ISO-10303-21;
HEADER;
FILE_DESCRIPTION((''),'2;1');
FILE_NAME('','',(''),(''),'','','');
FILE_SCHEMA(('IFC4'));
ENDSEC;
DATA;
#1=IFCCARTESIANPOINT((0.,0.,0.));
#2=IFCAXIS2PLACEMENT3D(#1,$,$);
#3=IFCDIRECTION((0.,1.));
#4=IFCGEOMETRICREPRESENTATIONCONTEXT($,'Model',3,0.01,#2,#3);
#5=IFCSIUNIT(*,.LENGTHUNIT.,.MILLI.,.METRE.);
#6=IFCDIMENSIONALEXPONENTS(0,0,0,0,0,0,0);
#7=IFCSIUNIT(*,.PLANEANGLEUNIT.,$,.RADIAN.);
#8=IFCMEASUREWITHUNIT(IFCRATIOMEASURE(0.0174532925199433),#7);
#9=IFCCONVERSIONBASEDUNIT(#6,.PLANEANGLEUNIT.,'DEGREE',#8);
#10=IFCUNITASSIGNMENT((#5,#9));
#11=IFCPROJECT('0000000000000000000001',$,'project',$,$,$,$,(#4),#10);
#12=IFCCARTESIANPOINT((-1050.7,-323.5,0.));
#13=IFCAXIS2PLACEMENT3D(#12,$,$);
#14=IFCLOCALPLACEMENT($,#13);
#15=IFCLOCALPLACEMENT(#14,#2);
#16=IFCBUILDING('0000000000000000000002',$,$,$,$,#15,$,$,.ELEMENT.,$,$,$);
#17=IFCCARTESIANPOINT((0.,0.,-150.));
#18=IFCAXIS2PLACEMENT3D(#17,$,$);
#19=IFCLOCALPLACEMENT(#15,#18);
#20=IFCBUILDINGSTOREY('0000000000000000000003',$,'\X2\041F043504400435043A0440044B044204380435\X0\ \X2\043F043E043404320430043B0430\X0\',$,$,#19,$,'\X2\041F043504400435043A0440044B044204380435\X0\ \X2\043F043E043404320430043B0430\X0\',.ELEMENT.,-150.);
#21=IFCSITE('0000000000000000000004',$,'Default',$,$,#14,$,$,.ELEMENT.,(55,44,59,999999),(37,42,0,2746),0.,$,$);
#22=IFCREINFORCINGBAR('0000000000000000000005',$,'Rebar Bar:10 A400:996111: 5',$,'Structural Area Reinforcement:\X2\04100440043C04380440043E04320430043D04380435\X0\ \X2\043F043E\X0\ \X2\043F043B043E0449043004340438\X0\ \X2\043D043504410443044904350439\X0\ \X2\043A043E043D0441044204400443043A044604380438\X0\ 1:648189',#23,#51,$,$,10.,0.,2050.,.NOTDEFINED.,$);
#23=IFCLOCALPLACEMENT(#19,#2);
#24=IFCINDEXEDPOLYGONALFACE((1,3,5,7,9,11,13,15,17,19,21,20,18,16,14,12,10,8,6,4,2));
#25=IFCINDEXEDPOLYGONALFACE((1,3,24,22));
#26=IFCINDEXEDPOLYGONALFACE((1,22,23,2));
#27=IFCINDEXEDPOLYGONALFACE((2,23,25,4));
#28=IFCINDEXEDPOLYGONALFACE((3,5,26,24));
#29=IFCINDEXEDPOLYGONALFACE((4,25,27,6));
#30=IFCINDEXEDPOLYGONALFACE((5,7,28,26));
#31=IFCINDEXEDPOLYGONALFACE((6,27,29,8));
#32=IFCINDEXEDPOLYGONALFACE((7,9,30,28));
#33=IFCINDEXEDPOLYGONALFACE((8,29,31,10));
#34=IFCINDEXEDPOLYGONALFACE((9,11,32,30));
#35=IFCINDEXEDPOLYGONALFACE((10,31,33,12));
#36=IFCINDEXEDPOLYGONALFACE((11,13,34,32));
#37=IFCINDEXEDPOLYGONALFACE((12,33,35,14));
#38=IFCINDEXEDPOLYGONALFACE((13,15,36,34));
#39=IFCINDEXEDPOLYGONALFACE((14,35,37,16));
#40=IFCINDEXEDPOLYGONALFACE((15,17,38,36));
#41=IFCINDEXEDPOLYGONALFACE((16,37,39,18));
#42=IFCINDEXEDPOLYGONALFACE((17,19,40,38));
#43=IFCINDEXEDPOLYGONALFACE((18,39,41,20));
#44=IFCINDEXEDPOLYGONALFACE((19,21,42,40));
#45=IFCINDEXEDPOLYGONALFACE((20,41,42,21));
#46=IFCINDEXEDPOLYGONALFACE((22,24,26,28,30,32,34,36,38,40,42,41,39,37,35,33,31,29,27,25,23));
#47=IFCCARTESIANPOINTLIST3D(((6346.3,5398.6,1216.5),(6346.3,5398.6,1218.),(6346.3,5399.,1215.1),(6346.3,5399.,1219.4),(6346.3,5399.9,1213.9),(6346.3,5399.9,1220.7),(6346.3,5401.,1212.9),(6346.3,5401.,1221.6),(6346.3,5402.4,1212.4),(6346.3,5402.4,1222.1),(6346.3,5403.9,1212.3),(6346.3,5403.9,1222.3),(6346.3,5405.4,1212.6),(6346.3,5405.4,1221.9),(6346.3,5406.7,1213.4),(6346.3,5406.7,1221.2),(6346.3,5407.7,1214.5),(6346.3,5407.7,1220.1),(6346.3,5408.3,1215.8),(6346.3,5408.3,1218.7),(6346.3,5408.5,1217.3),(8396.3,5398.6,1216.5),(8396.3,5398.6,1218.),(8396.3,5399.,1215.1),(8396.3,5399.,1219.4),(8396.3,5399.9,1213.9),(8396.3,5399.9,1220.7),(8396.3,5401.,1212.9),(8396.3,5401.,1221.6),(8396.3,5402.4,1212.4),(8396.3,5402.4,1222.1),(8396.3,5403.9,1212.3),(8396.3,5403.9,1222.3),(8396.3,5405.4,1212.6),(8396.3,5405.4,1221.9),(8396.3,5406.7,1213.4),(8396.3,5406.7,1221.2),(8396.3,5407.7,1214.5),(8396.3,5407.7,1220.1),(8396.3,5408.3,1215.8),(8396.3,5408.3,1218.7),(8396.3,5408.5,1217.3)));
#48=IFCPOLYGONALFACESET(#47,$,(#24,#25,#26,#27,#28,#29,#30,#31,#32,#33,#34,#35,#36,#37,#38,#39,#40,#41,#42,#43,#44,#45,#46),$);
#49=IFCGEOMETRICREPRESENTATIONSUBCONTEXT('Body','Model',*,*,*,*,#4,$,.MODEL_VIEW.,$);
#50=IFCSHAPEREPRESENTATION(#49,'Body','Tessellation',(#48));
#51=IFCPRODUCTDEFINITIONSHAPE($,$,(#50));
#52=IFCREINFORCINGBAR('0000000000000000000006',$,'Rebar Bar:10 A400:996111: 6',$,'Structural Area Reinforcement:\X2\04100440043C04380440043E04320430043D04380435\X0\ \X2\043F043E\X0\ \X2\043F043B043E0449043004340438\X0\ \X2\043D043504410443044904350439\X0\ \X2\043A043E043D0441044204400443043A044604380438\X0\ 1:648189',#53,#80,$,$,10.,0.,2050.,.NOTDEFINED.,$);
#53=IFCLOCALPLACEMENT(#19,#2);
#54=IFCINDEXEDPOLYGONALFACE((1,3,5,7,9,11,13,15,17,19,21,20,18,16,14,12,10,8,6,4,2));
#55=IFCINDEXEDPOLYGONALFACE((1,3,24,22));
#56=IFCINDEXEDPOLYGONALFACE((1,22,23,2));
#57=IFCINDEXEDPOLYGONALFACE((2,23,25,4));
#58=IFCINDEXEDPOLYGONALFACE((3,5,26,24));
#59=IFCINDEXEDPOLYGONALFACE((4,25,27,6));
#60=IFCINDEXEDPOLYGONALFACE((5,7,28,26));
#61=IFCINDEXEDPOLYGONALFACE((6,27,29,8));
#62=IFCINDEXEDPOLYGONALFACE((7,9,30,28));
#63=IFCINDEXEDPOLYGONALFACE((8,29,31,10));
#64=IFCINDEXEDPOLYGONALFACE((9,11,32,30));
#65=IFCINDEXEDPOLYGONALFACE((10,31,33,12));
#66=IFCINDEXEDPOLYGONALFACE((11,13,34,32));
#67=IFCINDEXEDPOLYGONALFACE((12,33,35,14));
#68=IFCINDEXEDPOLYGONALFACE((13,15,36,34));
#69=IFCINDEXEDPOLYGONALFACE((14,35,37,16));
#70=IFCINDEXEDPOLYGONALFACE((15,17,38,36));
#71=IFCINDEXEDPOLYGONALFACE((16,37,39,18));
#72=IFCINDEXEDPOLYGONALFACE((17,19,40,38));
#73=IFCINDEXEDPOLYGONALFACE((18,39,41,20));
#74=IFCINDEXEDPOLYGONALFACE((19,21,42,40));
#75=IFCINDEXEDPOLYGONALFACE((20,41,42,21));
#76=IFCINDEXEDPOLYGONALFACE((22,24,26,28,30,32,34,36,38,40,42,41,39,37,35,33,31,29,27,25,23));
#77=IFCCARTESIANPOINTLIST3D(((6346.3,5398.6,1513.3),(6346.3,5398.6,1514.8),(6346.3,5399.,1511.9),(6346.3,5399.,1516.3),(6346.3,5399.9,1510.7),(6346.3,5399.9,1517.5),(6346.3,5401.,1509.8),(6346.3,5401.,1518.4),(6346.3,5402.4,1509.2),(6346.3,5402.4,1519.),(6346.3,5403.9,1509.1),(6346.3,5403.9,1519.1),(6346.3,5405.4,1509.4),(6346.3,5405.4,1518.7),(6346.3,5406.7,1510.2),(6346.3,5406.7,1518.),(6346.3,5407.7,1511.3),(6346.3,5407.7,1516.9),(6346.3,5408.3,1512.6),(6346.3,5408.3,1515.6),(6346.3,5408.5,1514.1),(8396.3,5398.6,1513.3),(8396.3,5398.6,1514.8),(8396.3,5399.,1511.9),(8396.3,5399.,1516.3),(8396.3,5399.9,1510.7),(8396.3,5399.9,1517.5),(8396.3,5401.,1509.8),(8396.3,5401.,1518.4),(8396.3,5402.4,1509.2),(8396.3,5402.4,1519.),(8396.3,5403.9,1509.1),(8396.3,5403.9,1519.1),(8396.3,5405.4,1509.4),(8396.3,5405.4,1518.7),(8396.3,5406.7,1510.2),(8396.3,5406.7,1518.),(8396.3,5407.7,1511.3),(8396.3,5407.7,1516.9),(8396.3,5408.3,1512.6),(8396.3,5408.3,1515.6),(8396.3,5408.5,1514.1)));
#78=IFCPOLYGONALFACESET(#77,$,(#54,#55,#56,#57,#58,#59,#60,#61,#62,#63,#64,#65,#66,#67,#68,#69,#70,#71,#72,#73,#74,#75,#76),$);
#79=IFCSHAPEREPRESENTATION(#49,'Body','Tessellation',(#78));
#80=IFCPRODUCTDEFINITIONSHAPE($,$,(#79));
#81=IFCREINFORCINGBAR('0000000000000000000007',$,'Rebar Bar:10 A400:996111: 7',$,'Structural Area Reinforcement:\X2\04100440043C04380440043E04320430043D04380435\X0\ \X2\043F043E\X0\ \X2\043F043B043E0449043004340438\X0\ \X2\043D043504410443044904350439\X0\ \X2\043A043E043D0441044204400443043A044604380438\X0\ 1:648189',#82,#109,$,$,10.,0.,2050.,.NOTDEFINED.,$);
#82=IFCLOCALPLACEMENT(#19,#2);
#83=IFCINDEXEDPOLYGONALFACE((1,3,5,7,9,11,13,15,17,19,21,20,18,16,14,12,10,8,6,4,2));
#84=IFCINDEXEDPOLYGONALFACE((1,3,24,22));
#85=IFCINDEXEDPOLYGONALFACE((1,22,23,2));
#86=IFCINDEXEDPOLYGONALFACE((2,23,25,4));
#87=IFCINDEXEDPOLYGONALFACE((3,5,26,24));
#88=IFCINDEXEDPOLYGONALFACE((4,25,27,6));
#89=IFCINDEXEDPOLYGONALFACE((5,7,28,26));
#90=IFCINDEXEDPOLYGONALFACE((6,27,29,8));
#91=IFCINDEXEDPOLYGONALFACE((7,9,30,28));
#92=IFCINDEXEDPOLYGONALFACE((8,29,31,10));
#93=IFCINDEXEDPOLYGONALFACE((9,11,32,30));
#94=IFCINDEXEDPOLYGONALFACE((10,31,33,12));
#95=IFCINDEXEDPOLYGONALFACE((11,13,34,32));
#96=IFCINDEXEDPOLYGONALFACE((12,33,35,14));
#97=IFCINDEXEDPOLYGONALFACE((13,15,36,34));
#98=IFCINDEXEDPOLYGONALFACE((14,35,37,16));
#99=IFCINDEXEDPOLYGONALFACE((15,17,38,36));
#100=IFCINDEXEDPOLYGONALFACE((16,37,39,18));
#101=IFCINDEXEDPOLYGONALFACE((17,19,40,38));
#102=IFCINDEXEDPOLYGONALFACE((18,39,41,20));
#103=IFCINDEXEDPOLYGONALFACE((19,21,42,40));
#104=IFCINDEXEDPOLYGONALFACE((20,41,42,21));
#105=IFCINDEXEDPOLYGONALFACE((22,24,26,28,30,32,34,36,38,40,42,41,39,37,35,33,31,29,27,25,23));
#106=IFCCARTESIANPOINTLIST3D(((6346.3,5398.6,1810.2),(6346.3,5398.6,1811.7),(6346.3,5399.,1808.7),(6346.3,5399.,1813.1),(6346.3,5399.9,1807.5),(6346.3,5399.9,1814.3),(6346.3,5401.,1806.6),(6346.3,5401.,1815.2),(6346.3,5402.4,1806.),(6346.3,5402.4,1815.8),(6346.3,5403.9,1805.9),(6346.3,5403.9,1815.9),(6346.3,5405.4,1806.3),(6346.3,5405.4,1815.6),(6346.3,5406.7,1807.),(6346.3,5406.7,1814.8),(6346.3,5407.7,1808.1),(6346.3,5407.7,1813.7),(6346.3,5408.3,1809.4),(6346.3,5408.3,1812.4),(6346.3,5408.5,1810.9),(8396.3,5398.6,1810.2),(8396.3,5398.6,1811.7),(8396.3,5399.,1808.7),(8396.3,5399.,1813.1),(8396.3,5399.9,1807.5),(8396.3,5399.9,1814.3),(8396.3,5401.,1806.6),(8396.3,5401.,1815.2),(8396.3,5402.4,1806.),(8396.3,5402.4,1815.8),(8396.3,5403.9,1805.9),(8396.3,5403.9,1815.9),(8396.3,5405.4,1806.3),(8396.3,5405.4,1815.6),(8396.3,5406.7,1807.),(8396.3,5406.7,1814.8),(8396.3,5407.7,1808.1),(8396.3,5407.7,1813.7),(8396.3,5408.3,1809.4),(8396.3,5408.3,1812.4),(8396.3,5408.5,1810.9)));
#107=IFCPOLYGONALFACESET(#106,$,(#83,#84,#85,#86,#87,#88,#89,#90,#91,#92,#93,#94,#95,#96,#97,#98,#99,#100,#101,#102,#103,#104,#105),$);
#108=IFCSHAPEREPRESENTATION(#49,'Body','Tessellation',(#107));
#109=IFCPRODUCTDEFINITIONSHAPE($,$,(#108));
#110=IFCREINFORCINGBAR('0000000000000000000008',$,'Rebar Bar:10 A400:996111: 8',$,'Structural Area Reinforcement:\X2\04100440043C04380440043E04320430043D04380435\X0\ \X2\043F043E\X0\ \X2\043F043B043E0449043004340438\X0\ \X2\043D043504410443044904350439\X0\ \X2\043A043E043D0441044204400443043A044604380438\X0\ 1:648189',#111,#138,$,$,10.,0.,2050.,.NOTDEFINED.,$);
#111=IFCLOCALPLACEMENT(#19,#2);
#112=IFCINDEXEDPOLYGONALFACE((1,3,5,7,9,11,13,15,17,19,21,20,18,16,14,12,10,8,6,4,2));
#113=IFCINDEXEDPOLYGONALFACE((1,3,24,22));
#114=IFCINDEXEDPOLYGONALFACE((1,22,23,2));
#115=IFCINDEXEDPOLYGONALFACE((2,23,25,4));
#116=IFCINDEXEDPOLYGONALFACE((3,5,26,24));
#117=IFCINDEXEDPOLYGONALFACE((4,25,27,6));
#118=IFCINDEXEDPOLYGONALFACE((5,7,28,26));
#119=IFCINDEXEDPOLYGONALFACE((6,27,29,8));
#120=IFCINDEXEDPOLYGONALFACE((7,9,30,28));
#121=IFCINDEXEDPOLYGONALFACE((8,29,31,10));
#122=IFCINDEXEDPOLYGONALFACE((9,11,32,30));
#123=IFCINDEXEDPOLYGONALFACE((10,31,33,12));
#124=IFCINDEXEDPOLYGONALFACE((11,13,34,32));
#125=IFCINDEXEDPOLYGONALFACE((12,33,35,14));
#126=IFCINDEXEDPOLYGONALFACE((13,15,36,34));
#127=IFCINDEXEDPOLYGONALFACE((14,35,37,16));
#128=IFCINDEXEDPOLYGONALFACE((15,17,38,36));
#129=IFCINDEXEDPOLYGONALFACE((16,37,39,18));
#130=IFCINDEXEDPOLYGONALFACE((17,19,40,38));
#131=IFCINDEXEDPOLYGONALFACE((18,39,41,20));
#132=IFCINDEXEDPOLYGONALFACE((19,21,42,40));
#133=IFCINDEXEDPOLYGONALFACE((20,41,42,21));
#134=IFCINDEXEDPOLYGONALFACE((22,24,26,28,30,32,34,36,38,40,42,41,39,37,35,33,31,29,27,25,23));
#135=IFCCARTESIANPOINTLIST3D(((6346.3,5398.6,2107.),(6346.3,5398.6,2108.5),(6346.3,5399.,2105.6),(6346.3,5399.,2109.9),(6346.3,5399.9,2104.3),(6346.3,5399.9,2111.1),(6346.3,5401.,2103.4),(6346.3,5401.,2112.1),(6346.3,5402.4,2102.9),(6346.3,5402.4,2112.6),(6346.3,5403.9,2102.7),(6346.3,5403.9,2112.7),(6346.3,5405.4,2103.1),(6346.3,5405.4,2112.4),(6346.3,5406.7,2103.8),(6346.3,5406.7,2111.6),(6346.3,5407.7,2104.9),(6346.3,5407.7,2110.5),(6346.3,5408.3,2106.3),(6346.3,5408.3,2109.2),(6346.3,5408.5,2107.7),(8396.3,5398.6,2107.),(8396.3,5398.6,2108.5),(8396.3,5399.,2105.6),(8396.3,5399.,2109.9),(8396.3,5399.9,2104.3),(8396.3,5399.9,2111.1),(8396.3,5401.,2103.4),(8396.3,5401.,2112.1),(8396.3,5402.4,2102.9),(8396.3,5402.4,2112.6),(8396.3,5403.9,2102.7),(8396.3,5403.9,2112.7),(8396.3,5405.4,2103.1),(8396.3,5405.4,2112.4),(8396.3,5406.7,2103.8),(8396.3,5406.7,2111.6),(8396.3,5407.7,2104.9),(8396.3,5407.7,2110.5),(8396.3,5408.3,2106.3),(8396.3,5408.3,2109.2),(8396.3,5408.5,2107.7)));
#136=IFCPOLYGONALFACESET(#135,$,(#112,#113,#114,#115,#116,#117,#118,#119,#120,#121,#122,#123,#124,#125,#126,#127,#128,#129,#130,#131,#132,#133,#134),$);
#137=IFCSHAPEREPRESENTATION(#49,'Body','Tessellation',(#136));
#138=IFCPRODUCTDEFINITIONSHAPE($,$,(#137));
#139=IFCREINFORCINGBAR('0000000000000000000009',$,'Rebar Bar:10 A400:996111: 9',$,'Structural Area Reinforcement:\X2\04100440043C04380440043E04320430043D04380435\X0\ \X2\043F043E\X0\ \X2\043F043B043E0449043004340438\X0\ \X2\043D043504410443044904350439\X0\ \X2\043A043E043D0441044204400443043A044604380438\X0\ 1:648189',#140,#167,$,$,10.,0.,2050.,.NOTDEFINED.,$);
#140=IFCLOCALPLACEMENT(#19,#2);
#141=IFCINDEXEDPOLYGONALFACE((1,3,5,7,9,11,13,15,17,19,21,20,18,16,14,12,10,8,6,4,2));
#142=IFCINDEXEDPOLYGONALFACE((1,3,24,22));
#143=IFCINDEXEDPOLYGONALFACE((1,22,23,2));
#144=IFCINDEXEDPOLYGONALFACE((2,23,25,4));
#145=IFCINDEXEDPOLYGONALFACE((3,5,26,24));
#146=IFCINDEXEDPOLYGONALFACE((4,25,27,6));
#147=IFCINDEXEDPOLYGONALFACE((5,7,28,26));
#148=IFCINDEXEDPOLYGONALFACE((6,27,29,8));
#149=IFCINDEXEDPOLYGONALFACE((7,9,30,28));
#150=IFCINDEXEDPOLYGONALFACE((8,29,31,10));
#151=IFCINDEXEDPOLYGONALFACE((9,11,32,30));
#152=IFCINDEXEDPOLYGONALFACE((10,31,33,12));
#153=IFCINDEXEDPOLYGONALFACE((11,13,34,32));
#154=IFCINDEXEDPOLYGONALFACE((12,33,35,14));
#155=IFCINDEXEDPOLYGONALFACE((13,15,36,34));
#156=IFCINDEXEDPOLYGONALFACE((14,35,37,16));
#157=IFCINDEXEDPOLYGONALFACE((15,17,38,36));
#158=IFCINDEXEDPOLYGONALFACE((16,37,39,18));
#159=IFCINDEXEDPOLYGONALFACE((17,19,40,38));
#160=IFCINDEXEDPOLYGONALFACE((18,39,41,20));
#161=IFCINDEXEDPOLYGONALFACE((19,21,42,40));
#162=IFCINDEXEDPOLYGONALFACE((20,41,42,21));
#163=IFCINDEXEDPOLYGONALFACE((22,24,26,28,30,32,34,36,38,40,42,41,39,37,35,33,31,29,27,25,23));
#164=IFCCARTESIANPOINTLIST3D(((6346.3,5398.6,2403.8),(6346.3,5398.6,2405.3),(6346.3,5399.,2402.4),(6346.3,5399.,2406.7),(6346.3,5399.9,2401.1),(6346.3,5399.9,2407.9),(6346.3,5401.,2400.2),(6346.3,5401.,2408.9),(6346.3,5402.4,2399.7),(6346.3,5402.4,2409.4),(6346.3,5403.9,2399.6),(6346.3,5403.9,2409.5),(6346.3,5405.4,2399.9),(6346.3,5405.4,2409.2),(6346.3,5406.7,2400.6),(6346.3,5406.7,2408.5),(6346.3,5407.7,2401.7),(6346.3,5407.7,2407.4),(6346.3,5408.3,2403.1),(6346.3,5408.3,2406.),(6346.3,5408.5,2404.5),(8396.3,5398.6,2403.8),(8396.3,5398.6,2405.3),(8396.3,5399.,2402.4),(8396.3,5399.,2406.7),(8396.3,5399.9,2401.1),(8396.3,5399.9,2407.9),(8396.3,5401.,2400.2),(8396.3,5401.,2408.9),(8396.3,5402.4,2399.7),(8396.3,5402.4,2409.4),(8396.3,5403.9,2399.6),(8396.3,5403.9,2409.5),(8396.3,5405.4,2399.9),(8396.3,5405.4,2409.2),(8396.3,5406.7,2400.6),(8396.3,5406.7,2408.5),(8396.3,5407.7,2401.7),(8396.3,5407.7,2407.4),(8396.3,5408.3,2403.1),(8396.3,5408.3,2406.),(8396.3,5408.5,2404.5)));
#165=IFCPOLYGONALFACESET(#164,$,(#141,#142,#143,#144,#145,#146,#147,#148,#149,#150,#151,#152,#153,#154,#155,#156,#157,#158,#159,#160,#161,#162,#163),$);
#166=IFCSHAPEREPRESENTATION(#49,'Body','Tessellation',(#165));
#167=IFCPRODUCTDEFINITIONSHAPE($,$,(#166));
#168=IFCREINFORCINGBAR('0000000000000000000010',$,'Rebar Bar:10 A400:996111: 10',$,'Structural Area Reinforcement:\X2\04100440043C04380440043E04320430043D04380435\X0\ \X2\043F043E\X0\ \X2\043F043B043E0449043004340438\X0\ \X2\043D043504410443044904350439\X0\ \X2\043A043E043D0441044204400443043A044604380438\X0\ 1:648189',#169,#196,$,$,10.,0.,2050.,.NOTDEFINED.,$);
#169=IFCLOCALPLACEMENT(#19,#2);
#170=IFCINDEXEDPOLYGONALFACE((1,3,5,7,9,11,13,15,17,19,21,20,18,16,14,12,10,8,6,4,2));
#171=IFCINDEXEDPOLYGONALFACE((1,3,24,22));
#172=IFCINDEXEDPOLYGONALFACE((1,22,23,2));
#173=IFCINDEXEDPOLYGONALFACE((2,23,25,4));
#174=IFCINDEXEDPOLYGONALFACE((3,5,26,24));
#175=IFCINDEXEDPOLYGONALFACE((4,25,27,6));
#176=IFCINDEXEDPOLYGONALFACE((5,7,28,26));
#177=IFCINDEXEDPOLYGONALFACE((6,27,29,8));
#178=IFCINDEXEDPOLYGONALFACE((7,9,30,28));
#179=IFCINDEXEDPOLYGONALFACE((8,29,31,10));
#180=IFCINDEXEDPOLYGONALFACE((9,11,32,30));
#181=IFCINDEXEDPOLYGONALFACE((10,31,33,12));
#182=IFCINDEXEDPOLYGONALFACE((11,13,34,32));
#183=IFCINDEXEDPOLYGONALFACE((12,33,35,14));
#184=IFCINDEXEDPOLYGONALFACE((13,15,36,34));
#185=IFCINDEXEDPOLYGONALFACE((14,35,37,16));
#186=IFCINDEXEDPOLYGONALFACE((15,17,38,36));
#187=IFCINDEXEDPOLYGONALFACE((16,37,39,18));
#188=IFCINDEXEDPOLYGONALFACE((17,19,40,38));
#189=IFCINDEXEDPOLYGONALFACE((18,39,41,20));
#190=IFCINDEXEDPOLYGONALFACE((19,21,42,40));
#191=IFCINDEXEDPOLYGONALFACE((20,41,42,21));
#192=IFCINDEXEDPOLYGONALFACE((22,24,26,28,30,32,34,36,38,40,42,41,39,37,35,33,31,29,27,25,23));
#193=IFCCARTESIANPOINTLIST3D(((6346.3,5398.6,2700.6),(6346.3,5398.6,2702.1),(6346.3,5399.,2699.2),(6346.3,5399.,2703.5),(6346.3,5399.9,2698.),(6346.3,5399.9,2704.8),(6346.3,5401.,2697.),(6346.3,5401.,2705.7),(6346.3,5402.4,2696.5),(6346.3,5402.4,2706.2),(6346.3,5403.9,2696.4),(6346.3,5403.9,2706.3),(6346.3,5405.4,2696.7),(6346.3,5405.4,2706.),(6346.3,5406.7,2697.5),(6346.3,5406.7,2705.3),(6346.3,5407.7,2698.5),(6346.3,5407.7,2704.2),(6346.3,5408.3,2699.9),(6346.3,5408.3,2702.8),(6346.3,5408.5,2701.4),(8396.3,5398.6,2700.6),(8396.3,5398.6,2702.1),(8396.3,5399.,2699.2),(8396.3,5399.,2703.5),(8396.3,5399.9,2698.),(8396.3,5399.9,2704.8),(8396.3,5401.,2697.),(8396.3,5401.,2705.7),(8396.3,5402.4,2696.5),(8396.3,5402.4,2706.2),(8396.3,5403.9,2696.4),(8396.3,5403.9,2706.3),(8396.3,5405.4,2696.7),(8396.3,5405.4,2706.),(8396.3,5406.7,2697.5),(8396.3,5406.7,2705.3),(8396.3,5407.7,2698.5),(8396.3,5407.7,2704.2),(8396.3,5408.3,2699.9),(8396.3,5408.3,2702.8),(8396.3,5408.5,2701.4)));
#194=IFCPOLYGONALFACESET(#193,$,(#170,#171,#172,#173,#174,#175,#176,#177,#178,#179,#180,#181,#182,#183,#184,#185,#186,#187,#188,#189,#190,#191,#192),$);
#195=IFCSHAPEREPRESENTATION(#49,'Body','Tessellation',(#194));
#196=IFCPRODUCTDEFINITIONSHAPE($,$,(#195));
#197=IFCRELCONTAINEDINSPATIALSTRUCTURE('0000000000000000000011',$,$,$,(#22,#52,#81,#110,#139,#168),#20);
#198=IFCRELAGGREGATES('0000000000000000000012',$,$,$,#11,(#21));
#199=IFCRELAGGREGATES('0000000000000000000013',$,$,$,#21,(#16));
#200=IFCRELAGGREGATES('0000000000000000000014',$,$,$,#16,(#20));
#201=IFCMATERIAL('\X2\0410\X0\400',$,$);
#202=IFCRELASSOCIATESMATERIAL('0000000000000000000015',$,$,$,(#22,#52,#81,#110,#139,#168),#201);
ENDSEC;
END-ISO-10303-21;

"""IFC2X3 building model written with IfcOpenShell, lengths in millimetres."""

from ifc_helpers import new_model, entity, si_unit, converted_unit, direction, frame, origin, place, context, subcontext, project, spatial, material, element, save


model = new_model("IFC2X3")

# Units and contexts
model_context = context("Model", 3, precision=0.01, world=origin(), true_north=direction((0.0, 1.0)))
body_context = subcontext(model_context, "Body", "Model", "MODEL_VIEW")
ifc_project = project(units=[si_unit("LENGTHUNIT", "METRE", prefix="MILLI"), converted_unit("PLANEANGLEUNIT", "DEGREE", entity("IfcRatioMeasure", 0.0174532925199433), si_unit("PLANEANGLEUNIT", "RADIAN"), dimensions=[0, 0, 0, 0, 0, 0, 0])], contexts=[model_context])

# Site, building, storey
site_placement = place(None, frame((-1050.7, -323.5, 0.0)))
site = spatial("IfcSite", under=ifc_project, at=site_placement, Name="Default", CompositionType="ELEMENT", RefLatitude=(55, 44, 59, 999999), RefLongitude=(37, 42, 0, 2746), RefElevation=0.0)
building_placement = place(site_placement, origin())
building = spatial("IfcBuilding", under=site, at=building_placement, CompositionType="ELEMENT")
storey_placement = place(building_placement, frame((0.0, 0.0, -150.0)))
storey = spatial("IfcBuildingStorey", under=building, at=storey_placement, Name="Перекрытие подвала", LongName="Перекрытие подвала", CompositionType="ELEMENT", Elevation=-150.0)

# Reinforcing bars
ifc_material = material(Name="А400")
reinforcing_bar_1_placement = place(storey_placement, origin())
element("IfcReinforcingBar", 1, at=reinforcing_bar_1_placement, inside=storey, material=ifc_material, Name="Rebar Bar:10 A400:996111: 5", ObjectType="Structural Area Reinforcement:Армирование по площади несущей конструкции 1:648189", BarLength=2050.0, BarRole="NOTDEFINED", CrossSectionArea=0.0, NominalDiameter=10.0, context=body_context, shape_type="AdvancedSweptSolid", body=[
    entity("IfcSweptDiskSolid", entity("IfcCompositeCurve", [entity("IfcCompositeCurveSegment", "CONTINUOUS", True, entity("IfcPolyline", [entity("IfcCartesianPoint", [6346.3, 5403.5, 1217.3]), entity("IfcCartesianPoint", [8396.3, 5403.5, 1217.3])]))], False), 5.0, None, 0.0, 1.0),
])
reinforcing_bar_2_placement = place(storey_placement, origin())
element("IfcReinforcingBar", 2, at=reinforcing_bar_2_placement, inside=storey, material=ifc_material, Name="Rebar Bar:10 A400:996111: 6", ObjectType="Structural Area Reinforcement:Армирование по площади несущей конструкции 1:648189", BarLength=2050.0, BarRole="NOTDEFINED", CrossSectionArea=0.0, NominalDiameter=10.0, context=body_context, shape_type="AdvancedSweptSolid", body=[
    entity("IfcSweptDiskSolid", entity("IfcCompositeCurve", [entity("IfcCompositeCurveSegment", "CONTINUOUS", True, entity("IfcPolyline", [entity("IfcCartesianPoint", [6346.3, 5403.5, 1514.1]), entity("IfcCartesianPoint", [8396.3, 5403.5, 1514.1])]))], False), 5.0, None, 0.0, 1.0),
])
reinforcing_bar_3_placement = place(storey_placement, origin())
element("IfcReinforcingBar", 3, at=reinforcing_bar_3_placement, inside=storey, material=ifc_material, Name="Rebar Bar:10 A400:996111: 7", ObjectType="Structural Area Reinforcement:Армирование по площади несущей конструкции 1:648189", BarLength=2050.0, BarRole="NOTDEFINED", CrossSectionArea=0.0, NominalDiameter=10.0, context=body_context, shape_type="AdvancedSweptSolid", body=[
    entity("IfcSweptDiskSolid", entity("IfcCompositeCurve", [entity("IfcCompositeCurveSegment", "CONTINUOUS", True, entity("IfcPolyline", [entity("IfcCartesianPoint", [6346.3, 5403.5, 1810.9]), entity("IfcCartesianPoint", [8396.3, 5403.5, 1810.9])]))], False), 5.0, None, 0.0, 1.0),
])
reinforcing_bar_4_placement = place(storey_placement, origin())
element("IfcReinforcingBar", 4, at=reinforcing_bar_4_placement, inside=storey, material=ifc_material, Name="Rebar Bar:10 A400:996111: 8", ObjectType="Structural Area Reinforcement:Армирование по площади несущей конструкции 1:648189", BarLength=2050.0, BarRole="NOTDEFINED", CrossSectionArea=0.0, NominalDiameter=10.0, context=body_context, shape_type="AdvancedSweptSolid", body=[
    entity("IfcSweptDiskSolid", entity("IfcCompositeCurve", [entity("IfcCompositeCurveSegment", "CONTINUOUS", True, entity("IfcPolyline", [entity("IfcCartesianPoint", [6346.3, 5403.5, 2107.7]), entity("IfcCartesianPoint", [8396.3, 5403.5, 2107.7])]))], False), 5.0, None, 0.0, 1.0),
])
reinforcing_bar_5_placement = place(storey_placement, origin())
element("IfcReinforcingBar", 5, at=reinforcing_bar_5_placement, inside=storey, material=ifc_material, Name="Rebar Bar:10 A400:996111: 9", ObjectType="Structural Area Reinforcement:Армирование по площади несущей конструкции 1:648189", BarLength=2050.0, BarRole="NOTDEFINED", CrossSectionArea=0.0, NominalDiameter=10.0, context=body_context, shape_type="AdvancedSweptSolid", body=[
    entity("IfcSweptDiskSolid", entity("IfcCompositeCurve", [entity("IfcCompositeCurveSegment", "CONTINUOUS", True, entity("IfcPolyline", [entity("IfcCartesianPoint", [6346.3, 5403.5, 2404.5]), entity("IfcCartesianPoint", [8396.3, 5403.5, 2404.5])]))], False), 5.0, None, 0.0, 1.0),
])
reinforcing_bar_6_placement = place(storey_placement, origin())
element("IfcReinforcingBar", 6, at=reinforcing_bar_6_placement, inside=storey, material=ifc_material, Name="Rebar Bar:10 A400:996111: 10", ObjectType="Structural Area Reinforcement:Армирование по площади несущей конструкции 1:648189", BarLength=2050.0, BarRole="NOTDEFINED", CrossSectionArea=0.0, NominalDiameter=10.0, context=body_context, shape_type="AdvancedSweptSolid", body=[
    entity("IfcSweptDiskSolid", entity("IfcCompositeCurve", [entity("IfcCompositeCurveSegment", "CONTINUOUS", True, entity("IfcPolyline", [entity("IfcCartesianPoint", [6346.3, 5403.5, 2701.4]), entity("IfcCartesianPoint", [8396.3, 5403.5, 2701.4])]))], False), 5.0, None, 0.0, 1.0),
])

save(model, "model.ifc")
